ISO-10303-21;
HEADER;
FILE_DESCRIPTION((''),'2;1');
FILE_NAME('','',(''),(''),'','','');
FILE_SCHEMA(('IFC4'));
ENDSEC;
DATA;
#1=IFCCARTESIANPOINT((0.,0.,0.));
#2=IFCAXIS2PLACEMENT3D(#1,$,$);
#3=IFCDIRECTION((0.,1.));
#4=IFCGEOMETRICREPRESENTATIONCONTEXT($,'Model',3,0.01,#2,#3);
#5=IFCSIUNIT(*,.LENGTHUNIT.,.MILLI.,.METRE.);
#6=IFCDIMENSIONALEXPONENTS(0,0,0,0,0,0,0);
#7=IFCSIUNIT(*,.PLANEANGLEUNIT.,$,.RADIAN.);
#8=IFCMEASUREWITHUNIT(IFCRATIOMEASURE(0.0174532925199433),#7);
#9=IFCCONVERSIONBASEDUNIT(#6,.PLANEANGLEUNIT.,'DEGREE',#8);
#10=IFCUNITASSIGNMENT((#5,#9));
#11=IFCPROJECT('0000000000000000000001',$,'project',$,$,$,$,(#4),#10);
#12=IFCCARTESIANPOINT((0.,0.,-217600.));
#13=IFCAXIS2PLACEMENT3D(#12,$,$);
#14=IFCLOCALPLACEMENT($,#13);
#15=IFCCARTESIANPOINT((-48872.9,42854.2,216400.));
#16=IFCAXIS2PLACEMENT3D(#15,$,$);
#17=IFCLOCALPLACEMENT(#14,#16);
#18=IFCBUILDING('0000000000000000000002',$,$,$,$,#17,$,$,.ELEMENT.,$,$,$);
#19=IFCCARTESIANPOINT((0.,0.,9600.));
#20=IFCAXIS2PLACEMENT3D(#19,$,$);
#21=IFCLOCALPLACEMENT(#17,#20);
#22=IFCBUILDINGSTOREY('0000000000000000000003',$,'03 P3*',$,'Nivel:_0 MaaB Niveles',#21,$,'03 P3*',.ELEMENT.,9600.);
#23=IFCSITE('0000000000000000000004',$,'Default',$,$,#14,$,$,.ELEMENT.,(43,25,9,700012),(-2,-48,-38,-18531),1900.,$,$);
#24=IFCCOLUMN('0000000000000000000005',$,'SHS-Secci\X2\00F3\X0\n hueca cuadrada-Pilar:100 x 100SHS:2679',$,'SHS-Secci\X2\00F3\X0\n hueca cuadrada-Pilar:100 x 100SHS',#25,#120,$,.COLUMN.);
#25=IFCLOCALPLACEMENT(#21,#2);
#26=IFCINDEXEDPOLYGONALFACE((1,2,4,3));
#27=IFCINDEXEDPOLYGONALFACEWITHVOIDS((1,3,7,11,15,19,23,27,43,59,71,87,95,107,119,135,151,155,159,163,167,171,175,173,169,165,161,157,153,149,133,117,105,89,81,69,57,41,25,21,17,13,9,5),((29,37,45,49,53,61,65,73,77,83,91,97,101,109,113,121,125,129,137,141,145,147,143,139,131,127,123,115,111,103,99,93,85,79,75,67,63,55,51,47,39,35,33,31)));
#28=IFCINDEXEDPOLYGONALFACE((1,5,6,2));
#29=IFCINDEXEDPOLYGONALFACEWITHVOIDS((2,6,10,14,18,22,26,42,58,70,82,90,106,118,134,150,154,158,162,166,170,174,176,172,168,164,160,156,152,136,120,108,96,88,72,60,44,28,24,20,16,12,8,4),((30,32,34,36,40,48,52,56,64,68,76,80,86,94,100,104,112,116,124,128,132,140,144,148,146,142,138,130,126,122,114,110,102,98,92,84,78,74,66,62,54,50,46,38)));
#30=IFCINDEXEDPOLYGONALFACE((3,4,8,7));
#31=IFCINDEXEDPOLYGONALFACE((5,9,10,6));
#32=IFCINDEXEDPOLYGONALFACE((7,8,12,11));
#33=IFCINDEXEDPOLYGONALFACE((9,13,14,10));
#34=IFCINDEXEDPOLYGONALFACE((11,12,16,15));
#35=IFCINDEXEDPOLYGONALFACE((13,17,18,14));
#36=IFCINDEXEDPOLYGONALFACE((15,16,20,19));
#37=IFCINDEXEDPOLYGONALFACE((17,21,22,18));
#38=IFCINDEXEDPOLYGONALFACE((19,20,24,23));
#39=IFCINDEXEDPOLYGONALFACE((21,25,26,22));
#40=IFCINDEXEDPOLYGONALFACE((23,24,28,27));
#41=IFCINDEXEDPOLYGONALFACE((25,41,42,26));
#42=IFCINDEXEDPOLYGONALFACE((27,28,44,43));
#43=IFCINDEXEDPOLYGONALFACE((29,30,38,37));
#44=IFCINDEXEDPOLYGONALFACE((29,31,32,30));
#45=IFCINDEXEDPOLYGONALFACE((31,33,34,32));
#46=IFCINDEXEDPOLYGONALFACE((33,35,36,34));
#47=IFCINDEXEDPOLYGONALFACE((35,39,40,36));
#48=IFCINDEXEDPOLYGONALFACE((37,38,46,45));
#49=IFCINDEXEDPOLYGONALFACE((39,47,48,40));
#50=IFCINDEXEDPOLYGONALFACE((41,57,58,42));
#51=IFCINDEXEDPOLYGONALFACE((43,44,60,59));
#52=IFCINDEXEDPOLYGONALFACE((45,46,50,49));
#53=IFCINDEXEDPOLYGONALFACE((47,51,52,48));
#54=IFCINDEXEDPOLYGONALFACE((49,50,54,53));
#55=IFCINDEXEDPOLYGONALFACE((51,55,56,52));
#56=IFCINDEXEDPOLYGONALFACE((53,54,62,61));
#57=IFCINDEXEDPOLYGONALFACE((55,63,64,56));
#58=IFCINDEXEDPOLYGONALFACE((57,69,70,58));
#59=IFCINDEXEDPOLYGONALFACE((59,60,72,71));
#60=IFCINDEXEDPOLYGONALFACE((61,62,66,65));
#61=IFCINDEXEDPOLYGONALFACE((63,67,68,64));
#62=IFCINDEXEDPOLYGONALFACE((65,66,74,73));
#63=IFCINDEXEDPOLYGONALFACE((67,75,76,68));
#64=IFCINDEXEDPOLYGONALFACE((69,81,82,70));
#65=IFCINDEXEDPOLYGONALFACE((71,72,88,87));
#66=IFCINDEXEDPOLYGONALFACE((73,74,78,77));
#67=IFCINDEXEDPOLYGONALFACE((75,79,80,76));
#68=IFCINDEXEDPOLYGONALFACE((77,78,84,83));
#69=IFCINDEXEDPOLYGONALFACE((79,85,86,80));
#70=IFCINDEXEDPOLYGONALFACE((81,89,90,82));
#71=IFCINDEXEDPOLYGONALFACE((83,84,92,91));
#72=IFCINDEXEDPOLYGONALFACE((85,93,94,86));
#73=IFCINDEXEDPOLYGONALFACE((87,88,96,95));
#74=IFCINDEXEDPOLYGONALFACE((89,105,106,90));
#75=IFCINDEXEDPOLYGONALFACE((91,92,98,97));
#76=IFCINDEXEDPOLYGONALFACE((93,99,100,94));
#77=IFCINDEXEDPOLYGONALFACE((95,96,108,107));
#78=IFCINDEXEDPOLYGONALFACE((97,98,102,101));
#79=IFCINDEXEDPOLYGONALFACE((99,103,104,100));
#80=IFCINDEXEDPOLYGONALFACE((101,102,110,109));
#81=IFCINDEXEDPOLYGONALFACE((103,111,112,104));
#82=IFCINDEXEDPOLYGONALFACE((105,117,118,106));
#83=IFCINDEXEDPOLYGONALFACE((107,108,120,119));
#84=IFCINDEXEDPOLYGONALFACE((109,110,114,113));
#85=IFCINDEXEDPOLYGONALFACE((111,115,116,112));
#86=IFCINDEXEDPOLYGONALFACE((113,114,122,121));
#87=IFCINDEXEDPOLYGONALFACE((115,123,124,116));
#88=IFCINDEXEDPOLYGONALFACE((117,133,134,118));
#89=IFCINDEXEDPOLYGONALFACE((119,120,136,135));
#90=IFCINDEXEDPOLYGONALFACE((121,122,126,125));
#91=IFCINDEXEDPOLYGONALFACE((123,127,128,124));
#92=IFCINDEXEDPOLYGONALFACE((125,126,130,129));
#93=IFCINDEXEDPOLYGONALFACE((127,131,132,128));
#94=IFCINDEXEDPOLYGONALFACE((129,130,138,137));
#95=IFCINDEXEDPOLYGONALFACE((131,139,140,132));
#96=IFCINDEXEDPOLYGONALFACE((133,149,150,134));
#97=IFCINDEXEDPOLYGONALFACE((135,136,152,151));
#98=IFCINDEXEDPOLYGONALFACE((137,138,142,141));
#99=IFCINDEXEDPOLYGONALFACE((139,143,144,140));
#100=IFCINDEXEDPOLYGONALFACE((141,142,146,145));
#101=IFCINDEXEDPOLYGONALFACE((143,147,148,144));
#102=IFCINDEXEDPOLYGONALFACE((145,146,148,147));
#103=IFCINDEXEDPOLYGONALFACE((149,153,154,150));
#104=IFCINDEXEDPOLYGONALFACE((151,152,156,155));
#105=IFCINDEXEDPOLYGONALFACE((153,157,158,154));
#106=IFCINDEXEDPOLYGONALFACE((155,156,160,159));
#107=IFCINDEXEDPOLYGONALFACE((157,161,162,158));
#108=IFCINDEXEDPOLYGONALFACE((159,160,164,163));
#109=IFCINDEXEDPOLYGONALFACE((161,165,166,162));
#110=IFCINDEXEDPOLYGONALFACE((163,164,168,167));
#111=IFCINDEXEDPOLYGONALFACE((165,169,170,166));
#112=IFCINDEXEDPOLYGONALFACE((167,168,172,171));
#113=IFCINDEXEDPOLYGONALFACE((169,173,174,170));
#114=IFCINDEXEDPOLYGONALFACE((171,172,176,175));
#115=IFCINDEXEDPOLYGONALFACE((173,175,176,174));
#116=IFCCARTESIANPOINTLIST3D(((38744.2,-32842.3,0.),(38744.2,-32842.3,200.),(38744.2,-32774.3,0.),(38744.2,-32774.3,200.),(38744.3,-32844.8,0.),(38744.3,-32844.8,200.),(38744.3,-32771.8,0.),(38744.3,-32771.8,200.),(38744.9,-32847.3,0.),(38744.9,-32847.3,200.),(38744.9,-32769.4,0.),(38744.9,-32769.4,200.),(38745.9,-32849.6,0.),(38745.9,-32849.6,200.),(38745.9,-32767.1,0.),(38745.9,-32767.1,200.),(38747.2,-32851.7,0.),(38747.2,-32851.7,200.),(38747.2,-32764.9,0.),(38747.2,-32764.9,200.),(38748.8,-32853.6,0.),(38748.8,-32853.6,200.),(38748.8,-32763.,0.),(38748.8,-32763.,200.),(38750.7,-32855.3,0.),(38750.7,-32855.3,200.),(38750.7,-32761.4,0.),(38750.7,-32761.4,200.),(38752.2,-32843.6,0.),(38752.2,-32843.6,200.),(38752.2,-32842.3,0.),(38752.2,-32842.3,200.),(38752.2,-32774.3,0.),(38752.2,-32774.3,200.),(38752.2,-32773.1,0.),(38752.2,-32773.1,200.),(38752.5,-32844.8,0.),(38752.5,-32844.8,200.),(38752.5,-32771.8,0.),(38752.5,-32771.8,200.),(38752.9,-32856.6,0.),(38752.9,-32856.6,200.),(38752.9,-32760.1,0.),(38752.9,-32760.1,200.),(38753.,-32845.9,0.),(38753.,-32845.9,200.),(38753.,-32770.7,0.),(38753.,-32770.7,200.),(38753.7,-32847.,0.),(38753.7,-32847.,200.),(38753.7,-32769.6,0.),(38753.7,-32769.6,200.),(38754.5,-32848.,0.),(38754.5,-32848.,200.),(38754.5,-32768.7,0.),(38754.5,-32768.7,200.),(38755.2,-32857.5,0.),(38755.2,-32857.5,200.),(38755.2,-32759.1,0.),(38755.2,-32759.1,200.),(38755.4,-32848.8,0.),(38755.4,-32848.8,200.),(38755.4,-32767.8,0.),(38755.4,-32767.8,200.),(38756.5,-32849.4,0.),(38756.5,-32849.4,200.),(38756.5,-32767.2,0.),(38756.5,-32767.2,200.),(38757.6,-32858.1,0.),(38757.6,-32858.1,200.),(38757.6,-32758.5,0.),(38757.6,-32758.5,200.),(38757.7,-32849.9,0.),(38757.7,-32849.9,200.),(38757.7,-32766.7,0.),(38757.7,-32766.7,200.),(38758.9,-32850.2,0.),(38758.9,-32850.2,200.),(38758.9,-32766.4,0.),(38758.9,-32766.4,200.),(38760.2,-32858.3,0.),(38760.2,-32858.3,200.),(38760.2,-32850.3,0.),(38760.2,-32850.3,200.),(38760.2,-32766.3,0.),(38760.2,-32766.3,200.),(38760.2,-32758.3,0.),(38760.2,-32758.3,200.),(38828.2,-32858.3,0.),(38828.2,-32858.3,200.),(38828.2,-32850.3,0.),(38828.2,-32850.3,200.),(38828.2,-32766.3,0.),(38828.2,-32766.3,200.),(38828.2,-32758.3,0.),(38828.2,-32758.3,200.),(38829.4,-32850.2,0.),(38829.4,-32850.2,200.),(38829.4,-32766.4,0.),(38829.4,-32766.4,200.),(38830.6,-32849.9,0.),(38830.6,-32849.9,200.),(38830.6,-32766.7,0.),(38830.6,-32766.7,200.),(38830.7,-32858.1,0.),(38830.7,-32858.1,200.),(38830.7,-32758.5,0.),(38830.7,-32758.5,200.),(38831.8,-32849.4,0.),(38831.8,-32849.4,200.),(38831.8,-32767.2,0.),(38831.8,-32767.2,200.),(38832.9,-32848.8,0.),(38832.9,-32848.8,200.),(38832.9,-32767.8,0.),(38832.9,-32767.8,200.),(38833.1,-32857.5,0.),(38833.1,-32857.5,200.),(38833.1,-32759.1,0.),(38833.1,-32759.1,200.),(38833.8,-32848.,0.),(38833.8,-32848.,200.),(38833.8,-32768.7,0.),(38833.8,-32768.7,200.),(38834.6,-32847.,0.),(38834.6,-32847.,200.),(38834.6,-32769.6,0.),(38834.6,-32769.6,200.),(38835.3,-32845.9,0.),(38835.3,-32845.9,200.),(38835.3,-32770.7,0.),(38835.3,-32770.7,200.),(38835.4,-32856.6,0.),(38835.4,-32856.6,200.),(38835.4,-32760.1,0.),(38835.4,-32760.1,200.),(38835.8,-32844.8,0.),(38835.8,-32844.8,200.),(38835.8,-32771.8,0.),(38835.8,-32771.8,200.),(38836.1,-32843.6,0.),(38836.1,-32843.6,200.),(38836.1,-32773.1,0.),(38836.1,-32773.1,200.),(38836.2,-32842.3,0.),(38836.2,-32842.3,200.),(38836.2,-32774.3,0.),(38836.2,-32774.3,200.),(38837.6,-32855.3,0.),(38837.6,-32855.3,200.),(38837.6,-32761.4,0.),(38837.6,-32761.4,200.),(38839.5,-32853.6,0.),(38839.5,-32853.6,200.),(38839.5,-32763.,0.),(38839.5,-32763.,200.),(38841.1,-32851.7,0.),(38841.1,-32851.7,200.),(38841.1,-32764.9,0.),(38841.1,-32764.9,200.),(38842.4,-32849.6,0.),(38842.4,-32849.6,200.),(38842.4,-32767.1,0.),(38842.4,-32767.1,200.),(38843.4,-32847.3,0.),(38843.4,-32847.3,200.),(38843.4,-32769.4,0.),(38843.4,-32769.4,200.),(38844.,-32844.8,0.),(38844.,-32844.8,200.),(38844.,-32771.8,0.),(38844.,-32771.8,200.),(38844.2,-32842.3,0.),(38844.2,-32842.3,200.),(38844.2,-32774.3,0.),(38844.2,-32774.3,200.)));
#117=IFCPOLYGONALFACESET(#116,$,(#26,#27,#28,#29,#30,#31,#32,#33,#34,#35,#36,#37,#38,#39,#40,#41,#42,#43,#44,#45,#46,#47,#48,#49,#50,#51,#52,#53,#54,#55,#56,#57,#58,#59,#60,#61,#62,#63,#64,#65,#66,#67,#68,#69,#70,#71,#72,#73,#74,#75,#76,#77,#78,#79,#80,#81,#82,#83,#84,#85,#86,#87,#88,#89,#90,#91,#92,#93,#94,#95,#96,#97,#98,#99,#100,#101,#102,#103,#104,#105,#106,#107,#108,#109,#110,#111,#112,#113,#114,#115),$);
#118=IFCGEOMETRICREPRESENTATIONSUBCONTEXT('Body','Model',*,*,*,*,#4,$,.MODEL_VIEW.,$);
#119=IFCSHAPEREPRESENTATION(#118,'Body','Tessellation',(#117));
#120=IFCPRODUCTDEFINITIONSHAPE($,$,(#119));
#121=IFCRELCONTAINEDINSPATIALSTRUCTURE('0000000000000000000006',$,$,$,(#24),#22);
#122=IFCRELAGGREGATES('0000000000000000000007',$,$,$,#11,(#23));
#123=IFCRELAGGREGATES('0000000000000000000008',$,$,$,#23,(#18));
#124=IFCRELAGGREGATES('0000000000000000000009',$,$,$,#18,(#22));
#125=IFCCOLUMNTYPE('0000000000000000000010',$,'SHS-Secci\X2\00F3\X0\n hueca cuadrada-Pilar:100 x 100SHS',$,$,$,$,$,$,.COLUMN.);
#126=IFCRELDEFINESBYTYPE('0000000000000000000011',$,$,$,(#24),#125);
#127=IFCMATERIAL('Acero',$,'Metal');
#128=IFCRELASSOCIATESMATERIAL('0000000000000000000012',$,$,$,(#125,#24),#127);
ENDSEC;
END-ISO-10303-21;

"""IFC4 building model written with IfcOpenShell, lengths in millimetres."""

from ifc_helpers import new_model, entity, si_unit, converted_unit, direction, frame, origin, place, context, subcontext, project, spatial, indexed_curve, outline, extrude, source, transform, mapped, material, type_object, type_shapes, element, save


model = new_model("IFC4")

# Units and contexts
model_context = context("Model", 3, precision=0.01, world=origin(), true_north=direction((0.0, 1.0)))
body_context = subcontext(model_context, "Body", "Model", "MODEL_VIEW")
ifc_project = project(units=[si_unit("LENGTHUNIT", "METRE", prefix="MILLI"), converted_unit("PLANEANGLEUNIT", "DEGREE", entity("IfcRatioMeasure", 0.0174532925199433), si_unit("PLANEANGLEUNIT", "RADIAN"), dimensions=[0, 0, 0, 0, 0, 0, 0])], contexts=[model_context])

# Site, building, storey
site_placement = place(None, frame((0.0, 0.0, -217600.0)))
site = spatial("IfcSite", under=ifc_project, at=site_placement, Name="Default", CompositionType="ELEMENT", RefLatitude=(43, 25, 9, 700012), RefLongitude=(-2, -48, -38, -18531), RefElevation=1900.0)
building_placement = place(site_placement, frame((-48872.9, 42854.2, 216400.0)))
building = spatial("IfcBuilding", under=site, at=building_placement, CompositionType="ELEMENT")
storey_placement = place(building_placement, frame((0.0, 0.0, 9600.0)))
storey = spatial("IfcBuildingStorey", under=building, at=storey_placement, Name="03 P3*", ObjectType="Nivel:_0 MaaB Niveles", LongName="03 P3*", CompositionType="ELEMENT", Elevation=9600.0)

# Column
ifc_material_1 = material(Name="Acero", Category="Metal")
column_type_1 = type_object("IfcColumnType", Name="SHS-Sección hueca cuadrada-Pilar:100 x 100SHS", PredefinedType="COLUMN", material=ifc_material_1)
shared_shape_1 = source(origin(), body_context, "Body", "SweptSolid", [
    extrude(outline(indexed_curve([(-34.0, -50.0), (34.0, -50.0), (36.5, -49.8), (38.9, -49.2), (41.3, -48.3), (43.4, -46.9), (45.3, -45.3), (46.9, -43.4), (48.3, -41.3), (49.2, -38.9), (49.8, -36.5), (50.0, -34.0), (50.0, 34.0), (49.8, 36.5), (49.2, 38.9), (48.3, 41.3), (46.9, 43.4), (45.3, 45.3), (43.4, 46.9), (41.3, 48.3), (38.9, 49.2), (36.5, 49.8), (34.0, 50.0), (-34.0, 50.0), (-36.5, 49.8), (-38.9, 49.2), (-41.3, 48.3), (-43.4, 46.9), (-45.3, 45.3), (-46.9, 43.4), (-48.3, 41.3), (-49.2, 38.9), (-49.8, 36.5), (-50.0, 34.0), (-50.0, -34.0), (-49.8, -36.5), (-49.2, -38.9), (-48.3, -41.3), (-46.9, -43.4), (-45.3, -45.3), (-43.4, -46.9), (-41.3, -48.3), (-38.9, -49.2), (-36.5, -49.8), (-34.0, -50.0)], self_intersect=False), holes=[indexed_curve([(-42.0, 34.0), (-41.9, 35.3), (-41.6, 36.5), (-41.1, 37.6), (-40.5, 38.7), (-39.7, 39.7), (-38.7, 40.5), (-37.6, 41.1), (-36.5, 41.6), (-35.3, 41.9), (-34.0, 42.0), (34.0, 42.0), (35.3, 41.9), (36.5, 41.6), (37.6, 41.1), (38.7, 40.5), (39.7, 39.7), (40.5, 38.7), (41.1, 37.6), (41.6, 36.5), (41.9, 35.3), (42.0, 34.0), (42.0, -34.0), (41.9, -35.3), (41.6, -36.5), (41.1, -37.6), (40.5, -38.7), (39.7, -39.7), (38.7, -40.5), (37.6, -41.1), (36.5, -41.6), (35.3, -41.9), (34.0, -42.0), (-34.0, -42.0), (-35.3, -41.9), (-36.5, -41.6), (-37.6, -41.1), (-38.7, -40.5), (-39.7, -39.7), (-40.5, -38.7), (-41.1, -37.6), (-41.6, -36.5), (-41.9, -35.3), (-42.0, -34.0), (-42.0, 34.0)], self_intersect=False)]), frame((0.0, 0.0, 9600.0), z_axis=(0.0, 0.0, 1.0), x_axis=(0.0, 1.0, 0.0)), (0.0, 0.0, 1.0), 200.0),
])
type_shapes(column_type_1, [shared_shape_1])
column_1_placement = place(storey_placement, frame((38794.2, -32808.3, -9600.0), z_axis=(0.0, 0.0, 1.0), x_axis=(0.0, -1.0, 0.0)))
element("IfcColumn", 1, at=column_1_placement, inside=storey, type_object=column_type_1, material=ifc_material_1, Name="SHS-Sección hueca cuadrada-Pilar:100 x 100SHS:2679", ObjectType="SHS-Sección hueca cuadrada-Pilar:100 x 100SHS", PredefinedType="COLUMN", context=body_context, shape_type="MappedRepresentation", body=[
    mapped(shared_shape_1, transform((0.0, 0.0, 0.0), scale=1.0)),
])

save(model, "model.ifc")
